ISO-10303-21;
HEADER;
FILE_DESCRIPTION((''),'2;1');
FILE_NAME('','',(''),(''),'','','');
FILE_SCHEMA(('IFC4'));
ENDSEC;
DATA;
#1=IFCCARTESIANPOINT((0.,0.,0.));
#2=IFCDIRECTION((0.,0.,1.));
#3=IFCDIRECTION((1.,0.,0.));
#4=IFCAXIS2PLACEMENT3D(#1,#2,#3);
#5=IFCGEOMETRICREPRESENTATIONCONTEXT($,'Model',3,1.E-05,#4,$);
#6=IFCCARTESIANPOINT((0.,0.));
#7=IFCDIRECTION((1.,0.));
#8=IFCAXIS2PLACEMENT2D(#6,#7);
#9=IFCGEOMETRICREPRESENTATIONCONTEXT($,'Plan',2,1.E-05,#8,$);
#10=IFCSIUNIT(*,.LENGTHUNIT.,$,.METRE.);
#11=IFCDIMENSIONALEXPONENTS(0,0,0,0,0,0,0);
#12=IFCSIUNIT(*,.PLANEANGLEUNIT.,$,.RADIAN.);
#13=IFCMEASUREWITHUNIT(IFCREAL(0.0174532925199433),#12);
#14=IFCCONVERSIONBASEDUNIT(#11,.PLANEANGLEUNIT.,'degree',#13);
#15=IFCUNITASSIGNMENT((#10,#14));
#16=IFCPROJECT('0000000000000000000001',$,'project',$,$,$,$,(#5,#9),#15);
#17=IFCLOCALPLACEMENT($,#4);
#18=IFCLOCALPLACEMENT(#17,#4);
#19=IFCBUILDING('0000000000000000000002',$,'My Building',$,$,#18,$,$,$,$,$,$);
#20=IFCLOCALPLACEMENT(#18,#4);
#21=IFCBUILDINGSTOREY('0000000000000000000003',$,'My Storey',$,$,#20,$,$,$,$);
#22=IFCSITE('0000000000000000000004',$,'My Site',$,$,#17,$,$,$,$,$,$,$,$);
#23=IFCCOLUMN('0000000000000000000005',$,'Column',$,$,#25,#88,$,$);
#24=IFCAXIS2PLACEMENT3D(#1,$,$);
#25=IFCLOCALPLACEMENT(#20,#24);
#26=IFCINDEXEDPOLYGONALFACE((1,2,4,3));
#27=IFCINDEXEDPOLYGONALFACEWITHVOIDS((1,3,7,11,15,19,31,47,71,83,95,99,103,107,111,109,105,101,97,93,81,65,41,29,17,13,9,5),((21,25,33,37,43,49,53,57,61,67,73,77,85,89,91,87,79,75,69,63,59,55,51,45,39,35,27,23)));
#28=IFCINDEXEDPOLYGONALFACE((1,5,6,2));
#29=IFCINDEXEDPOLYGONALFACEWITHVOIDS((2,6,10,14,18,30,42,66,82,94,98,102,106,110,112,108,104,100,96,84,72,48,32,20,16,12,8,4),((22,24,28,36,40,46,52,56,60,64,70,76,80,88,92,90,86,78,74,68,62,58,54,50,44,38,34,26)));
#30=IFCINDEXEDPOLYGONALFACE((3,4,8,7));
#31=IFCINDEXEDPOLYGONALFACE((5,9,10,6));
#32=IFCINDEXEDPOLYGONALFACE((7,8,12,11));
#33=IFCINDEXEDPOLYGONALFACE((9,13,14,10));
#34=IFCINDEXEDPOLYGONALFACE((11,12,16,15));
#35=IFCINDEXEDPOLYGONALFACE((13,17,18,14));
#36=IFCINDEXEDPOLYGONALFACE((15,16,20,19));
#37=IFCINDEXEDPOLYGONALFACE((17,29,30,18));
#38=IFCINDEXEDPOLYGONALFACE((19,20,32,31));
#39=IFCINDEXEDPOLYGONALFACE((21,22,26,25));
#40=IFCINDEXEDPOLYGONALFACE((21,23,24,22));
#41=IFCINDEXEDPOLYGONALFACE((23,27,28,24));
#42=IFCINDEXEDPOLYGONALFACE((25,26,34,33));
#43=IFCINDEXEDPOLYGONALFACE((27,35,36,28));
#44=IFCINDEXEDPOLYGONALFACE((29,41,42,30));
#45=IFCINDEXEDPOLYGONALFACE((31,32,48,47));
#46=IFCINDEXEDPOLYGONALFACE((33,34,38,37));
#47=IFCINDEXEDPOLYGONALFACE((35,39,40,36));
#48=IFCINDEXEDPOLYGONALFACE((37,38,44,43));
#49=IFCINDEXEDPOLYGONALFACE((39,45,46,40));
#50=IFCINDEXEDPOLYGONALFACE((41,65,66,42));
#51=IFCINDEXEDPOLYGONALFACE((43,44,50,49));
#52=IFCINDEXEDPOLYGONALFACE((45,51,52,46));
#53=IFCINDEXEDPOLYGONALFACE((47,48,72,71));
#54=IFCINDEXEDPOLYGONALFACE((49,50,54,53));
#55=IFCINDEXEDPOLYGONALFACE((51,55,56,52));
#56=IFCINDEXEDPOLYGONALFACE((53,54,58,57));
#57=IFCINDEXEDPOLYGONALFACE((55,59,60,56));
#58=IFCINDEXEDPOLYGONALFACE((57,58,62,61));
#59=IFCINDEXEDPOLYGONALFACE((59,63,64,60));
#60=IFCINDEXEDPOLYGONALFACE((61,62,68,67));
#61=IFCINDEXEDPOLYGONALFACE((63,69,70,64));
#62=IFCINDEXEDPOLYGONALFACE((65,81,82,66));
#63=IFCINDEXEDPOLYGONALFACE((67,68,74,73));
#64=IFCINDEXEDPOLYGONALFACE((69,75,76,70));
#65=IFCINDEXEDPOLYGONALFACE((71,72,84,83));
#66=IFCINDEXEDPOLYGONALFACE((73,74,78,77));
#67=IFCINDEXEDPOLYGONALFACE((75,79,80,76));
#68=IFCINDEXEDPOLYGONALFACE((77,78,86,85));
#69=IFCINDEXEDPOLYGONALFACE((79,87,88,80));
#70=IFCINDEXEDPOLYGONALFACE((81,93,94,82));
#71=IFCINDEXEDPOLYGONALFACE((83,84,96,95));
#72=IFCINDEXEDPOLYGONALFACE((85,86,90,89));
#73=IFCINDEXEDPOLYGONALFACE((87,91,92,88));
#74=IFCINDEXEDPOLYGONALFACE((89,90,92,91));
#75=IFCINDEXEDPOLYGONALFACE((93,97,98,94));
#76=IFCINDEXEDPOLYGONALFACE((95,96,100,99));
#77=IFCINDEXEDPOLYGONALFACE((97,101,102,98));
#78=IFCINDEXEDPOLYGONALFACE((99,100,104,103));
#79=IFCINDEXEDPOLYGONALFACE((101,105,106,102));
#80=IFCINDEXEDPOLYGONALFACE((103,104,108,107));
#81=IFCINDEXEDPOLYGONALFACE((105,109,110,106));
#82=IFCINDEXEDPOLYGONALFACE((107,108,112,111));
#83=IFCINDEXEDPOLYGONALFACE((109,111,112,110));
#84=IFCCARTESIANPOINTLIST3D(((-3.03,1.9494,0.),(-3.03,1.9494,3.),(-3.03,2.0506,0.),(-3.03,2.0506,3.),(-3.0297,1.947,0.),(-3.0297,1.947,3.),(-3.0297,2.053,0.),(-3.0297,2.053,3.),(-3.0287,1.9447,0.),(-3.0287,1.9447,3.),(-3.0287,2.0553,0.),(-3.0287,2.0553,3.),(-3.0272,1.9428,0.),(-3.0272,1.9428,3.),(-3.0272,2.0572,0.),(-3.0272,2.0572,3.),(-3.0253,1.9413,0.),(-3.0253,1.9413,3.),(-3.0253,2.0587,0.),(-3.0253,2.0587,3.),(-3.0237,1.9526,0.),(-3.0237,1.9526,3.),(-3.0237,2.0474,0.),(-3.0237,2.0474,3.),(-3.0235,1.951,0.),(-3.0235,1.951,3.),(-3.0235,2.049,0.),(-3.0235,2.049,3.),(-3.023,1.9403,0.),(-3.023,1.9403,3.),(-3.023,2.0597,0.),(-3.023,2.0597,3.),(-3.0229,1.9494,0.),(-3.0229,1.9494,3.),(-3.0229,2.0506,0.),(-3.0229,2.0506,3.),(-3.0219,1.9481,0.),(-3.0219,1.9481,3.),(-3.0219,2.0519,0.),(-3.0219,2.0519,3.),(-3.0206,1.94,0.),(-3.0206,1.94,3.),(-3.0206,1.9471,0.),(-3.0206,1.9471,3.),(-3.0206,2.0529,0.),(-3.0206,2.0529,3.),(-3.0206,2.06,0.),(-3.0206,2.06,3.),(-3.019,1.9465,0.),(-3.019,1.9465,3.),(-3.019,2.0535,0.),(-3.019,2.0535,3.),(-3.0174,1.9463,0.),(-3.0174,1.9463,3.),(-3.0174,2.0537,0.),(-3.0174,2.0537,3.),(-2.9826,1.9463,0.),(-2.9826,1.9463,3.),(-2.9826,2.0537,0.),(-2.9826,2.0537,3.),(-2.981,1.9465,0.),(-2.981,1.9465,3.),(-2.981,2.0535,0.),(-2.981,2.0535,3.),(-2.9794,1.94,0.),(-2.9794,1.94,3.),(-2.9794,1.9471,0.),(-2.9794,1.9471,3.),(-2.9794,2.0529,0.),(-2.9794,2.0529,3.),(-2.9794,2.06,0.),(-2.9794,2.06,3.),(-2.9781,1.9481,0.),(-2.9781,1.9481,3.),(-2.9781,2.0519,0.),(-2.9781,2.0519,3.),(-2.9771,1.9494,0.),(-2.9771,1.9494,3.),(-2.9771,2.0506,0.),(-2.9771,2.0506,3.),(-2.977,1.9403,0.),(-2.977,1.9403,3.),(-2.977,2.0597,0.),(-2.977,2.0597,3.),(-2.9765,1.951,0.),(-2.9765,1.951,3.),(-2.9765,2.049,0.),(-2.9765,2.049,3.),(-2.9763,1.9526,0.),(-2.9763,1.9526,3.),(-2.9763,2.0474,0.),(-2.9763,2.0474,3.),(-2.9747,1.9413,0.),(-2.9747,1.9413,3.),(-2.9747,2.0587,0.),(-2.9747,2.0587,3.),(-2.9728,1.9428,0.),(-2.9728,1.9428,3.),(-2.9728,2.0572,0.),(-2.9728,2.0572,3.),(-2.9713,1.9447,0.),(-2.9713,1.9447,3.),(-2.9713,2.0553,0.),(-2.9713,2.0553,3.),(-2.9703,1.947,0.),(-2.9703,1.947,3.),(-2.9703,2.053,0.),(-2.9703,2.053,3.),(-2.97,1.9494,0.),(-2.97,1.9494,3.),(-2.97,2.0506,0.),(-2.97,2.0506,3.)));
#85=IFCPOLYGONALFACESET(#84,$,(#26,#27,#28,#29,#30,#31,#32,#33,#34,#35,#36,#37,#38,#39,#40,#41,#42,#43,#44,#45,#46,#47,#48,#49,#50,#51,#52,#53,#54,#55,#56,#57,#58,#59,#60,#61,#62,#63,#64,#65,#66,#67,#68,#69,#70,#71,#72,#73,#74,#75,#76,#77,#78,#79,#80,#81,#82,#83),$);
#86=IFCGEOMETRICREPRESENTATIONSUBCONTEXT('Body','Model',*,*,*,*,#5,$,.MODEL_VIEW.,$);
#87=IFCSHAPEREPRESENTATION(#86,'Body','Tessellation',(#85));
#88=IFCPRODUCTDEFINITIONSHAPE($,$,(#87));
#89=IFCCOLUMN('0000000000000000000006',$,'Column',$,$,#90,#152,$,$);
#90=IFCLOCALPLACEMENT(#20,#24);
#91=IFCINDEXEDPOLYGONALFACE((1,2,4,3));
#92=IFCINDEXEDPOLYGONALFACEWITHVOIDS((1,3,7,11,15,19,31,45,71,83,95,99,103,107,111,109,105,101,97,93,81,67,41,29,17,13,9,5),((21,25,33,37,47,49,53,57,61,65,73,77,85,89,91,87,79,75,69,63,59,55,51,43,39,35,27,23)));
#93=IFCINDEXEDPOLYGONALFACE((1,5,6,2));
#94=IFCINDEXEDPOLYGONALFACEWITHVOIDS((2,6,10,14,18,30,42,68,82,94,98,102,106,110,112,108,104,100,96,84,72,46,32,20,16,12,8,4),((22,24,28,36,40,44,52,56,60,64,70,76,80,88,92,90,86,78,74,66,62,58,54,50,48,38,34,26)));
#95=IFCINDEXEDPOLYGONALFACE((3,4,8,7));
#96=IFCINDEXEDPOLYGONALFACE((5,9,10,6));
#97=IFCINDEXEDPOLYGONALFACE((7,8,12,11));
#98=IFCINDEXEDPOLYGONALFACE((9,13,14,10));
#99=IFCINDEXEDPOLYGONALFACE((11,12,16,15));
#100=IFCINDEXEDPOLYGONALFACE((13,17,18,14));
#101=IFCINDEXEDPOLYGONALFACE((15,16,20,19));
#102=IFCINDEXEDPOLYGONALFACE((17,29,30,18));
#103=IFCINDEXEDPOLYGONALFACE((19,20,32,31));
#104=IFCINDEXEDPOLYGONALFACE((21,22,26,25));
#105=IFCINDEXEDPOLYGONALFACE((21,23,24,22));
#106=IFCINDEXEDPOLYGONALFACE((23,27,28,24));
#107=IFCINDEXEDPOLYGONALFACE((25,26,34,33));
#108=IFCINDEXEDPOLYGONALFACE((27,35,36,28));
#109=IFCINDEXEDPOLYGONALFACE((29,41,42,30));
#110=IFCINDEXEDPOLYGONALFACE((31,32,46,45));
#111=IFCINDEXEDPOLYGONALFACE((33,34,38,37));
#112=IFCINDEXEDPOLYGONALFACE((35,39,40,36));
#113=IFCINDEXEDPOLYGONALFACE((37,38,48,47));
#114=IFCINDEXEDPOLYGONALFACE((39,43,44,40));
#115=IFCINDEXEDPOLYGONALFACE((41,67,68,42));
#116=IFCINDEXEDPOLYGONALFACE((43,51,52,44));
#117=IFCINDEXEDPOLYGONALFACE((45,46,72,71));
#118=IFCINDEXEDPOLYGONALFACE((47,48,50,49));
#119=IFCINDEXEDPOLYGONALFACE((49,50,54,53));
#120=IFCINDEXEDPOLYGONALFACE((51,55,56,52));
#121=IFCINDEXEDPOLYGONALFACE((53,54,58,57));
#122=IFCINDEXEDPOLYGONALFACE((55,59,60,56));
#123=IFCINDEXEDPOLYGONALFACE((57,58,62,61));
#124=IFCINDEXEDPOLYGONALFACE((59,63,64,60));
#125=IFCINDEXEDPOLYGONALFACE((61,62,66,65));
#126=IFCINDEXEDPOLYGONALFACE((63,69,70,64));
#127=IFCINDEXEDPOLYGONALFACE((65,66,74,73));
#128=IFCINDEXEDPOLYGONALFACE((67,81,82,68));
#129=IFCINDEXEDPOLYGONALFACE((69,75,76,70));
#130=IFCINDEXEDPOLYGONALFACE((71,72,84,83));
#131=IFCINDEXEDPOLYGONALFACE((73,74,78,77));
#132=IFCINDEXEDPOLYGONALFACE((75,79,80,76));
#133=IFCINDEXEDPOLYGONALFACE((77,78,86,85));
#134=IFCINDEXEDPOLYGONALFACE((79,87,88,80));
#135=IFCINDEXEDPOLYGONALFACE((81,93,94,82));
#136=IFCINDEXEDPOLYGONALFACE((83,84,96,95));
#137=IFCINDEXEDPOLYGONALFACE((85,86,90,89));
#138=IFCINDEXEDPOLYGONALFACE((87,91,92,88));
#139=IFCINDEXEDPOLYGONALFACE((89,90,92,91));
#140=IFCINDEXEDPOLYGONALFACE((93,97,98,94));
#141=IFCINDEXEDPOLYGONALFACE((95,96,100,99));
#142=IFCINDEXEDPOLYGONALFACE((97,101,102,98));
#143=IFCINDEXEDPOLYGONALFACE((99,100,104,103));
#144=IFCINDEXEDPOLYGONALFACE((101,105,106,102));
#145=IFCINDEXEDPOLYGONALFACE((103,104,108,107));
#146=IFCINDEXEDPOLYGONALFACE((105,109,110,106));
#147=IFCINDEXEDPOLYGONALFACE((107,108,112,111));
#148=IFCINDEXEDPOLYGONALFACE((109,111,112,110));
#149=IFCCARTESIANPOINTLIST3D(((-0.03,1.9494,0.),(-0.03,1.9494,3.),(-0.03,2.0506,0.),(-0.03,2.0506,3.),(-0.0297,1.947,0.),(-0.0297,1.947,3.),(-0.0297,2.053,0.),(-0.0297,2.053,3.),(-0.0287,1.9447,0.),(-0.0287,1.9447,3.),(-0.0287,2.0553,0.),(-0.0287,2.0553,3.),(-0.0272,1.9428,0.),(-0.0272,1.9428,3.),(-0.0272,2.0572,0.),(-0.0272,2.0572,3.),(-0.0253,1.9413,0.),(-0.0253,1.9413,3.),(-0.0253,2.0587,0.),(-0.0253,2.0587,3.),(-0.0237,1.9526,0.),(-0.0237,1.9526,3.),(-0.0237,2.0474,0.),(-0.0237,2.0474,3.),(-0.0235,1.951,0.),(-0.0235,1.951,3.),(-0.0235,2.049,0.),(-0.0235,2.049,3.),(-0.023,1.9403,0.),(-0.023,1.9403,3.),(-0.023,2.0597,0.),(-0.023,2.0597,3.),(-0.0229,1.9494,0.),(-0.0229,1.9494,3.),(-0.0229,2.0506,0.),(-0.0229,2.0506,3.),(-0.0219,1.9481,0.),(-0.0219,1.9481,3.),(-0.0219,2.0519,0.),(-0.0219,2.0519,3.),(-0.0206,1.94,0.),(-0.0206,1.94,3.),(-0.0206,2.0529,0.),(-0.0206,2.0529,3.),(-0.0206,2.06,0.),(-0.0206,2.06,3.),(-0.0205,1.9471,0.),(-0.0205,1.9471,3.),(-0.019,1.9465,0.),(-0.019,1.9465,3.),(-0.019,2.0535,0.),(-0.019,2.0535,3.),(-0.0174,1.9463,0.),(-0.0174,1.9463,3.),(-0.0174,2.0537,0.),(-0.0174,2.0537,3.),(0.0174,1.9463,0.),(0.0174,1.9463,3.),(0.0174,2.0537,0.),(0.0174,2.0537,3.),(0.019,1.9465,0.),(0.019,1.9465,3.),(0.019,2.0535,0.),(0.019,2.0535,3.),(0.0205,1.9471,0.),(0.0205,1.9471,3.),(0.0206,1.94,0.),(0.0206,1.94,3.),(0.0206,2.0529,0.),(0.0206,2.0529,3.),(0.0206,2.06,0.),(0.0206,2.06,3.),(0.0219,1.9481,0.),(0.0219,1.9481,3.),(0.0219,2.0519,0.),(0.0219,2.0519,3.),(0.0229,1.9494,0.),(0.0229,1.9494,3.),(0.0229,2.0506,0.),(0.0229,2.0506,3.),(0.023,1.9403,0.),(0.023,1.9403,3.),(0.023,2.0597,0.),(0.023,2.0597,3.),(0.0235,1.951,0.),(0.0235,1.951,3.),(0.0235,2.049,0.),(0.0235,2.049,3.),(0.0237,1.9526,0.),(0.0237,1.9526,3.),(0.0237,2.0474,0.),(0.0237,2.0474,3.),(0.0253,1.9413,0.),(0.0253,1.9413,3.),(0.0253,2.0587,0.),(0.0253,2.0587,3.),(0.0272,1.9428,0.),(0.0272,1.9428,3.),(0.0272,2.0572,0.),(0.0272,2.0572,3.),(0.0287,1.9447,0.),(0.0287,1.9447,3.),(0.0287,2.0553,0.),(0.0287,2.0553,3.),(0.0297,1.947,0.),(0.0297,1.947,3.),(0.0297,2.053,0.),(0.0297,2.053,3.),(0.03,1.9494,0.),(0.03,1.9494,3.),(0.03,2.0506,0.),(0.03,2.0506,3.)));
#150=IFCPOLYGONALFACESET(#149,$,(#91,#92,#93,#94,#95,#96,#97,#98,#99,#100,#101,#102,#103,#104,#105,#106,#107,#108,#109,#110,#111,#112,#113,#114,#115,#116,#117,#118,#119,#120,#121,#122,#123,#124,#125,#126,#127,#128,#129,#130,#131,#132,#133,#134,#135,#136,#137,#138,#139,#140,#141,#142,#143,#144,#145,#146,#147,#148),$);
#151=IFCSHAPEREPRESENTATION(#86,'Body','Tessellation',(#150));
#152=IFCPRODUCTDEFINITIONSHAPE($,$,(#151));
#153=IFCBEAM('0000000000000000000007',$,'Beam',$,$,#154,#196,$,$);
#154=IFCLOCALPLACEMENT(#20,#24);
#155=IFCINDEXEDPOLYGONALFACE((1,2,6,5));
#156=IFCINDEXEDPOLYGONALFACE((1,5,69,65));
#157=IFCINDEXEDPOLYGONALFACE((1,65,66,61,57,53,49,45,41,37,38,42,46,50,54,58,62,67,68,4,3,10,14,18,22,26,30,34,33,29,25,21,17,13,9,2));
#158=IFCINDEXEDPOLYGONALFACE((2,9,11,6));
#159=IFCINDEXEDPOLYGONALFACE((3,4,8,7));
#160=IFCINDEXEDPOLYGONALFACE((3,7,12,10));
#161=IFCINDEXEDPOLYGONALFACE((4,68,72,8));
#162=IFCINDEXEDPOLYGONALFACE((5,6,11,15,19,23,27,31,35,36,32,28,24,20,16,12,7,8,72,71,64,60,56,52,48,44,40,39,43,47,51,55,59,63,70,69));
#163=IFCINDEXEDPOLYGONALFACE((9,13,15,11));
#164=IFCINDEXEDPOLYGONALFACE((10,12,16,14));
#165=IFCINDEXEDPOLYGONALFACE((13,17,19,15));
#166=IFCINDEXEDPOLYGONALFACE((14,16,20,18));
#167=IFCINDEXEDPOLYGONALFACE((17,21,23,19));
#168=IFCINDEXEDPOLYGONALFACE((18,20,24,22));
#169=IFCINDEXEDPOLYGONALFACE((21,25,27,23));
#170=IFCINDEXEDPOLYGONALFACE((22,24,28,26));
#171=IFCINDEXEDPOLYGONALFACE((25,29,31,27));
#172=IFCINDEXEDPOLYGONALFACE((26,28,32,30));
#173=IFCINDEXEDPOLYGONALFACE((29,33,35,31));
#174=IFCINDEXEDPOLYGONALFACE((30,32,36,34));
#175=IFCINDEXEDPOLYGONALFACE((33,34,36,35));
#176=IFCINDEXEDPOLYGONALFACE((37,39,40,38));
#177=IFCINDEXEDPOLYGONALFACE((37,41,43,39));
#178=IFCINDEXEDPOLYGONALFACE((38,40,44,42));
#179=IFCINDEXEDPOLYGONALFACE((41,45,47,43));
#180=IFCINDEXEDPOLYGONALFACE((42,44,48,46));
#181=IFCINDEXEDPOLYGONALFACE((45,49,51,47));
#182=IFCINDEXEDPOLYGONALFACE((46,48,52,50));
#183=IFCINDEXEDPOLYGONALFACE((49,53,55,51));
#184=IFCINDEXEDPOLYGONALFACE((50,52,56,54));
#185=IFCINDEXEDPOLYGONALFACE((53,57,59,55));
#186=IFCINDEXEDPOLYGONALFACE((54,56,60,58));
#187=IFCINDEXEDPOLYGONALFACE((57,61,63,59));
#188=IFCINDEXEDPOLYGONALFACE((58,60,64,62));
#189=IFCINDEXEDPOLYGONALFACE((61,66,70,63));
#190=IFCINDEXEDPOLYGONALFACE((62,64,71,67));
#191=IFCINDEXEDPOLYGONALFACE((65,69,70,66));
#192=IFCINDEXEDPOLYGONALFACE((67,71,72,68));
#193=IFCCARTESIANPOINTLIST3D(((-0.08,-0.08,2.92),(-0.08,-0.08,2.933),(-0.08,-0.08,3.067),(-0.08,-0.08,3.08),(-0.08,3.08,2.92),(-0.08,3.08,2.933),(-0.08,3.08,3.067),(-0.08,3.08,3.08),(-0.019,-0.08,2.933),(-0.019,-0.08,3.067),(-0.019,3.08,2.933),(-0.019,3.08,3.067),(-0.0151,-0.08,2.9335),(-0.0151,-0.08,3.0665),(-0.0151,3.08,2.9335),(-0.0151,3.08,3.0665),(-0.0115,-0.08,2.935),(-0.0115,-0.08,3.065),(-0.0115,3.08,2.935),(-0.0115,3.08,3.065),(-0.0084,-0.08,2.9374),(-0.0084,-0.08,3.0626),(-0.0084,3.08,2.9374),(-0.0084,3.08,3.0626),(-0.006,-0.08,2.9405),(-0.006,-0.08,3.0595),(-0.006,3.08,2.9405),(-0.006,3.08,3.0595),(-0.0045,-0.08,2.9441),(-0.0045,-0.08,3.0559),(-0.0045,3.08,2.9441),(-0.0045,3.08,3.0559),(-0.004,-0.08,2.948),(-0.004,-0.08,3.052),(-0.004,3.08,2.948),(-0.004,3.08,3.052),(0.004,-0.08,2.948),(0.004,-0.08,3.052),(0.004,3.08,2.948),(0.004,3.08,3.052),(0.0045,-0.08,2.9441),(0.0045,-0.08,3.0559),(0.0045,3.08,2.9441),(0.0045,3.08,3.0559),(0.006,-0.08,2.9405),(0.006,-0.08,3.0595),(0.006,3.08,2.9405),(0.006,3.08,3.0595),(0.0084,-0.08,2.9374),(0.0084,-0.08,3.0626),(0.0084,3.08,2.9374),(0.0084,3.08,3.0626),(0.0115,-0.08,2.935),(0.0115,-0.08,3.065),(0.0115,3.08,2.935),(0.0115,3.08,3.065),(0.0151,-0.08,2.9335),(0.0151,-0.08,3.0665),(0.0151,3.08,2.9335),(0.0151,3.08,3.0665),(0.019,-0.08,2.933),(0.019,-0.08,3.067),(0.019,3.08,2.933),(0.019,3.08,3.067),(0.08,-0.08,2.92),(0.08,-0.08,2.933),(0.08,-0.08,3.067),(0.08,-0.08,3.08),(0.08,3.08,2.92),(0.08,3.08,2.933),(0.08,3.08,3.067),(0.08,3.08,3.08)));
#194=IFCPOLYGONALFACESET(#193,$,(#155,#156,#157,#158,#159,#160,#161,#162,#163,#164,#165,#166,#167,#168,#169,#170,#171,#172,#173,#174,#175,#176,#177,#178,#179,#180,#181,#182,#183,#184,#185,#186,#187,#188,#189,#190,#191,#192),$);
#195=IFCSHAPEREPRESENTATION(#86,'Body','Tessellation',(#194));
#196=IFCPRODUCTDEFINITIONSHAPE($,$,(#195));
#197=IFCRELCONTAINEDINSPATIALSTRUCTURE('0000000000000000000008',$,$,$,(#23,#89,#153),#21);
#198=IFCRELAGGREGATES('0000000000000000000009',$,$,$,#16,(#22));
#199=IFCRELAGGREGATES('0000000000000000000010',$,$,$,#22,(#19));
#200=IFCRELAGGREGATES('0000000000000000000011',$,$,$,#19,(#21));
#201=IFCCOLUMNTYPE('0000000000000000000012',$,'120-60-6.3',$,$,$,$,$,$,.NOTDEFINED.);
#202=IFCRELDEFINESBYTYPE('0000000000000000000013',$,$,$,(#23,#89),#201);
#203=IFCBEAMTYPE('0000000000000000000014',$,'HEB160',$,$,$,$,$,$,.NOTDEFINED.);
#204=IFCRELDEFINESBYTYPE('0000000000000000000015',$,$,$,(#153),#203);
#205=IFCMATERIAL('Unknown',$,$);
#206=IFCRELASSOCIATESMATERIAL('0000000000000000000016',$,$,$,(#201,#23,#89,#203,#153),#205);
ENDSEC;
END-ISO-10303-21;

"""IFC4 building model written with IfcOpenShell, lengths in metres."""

from ifc_helpers import new_model, entity, si_unit, converted_unit, frame, origin_with_axes, origin_2d_with_axis, place, context, subcontext, project, spatial, hollow_rectangle, i_section, extrude, material, material_profile, profile_set, profile_usage, type_object, element, save


model = new_model("IFC4")

# Units and contexts
model_context = context("Model", 3, precision=1e-05, world=origin_with_axes())
plan_context = context("Plan", 2, precision=1e-05, world=origin_2d_with_axis())
body_context = subcontext(model_context, "Body", "Model", "MODEL_VIEW")
ifc_project = project(units=[si_unit("LENGTHUNIT", "METRE"), converted_unit("PLANEANGLEUNIT", "degree", entity("IfcReal", 0.0174532925199433), si_unit("PLANEANGLEUNIT", "RADIAN"), dimensions=[0, 0, 0, 0, 0, 0, 0])], contexts=[model_context, plan_context])

# Site, building, storey
site_placement = place(None, origin_with_axes())
site = spatial("IfcSite", under=ifc_project, at=site_placement, Name="My Site")
building_placement = place(site_placement, origin_with_axes())
building = spatial("IfcBuilding", under=site, at=building_placement, Name="My Building")
storey_placement = place(building_placement, origin_with_axes())
storey = spatial("IfcBuildingStorey", under=building, at=storey_placement, Name="My Storey")

# Columns
ifc_material = material(Name="Unknown")
ifc_material_profile_1 = material_profile(ifc_material, hollow_rectangle(XDim=0.06, YDim=0.12, WallThickness=0.0063, InnerFilletRadius=0.0063, OuterFilletRadius=0.0095))
ifc_profile_set_1 = profile_set([ifc_material_profile_1])
column_type = type_object("IfcColumnType", Name="120-60-6.3", PredefinedType="NOTDEFINED", material=ifc_profile_set_1)
ifc_profile_usage_1 = profile_usage(ifc_profile_set_1, cardinal=5)
column_1_placement = place(storey_placement, frame((-3.0, 2.0, 0.0), z_axis=(0.0, 0.0, 1.0), x_axis=(1.0, 0.0, 0.0)))
element("IfcColumn", 1, at=column_1_placement, inside=storey, type_object=column_type, material=ifc_profile_usage_1, Name="Column", context=body_context, shape_type="SweptSolid", body=[
    extrude(hollow_rectangle(XDim=0.06, YDim=0.12, WallThickness=0.0063, InnerFilletRadius=0.0063, OuterFilletRadius=0.0095), origin_with_axes(), (0.0, 0.0, 1.0), 3.0),
])
ifc_profile_usage_2 = profile_usage(ifc_profile_set_1, cardinal=5)
column_2_placement = place(storey_placement, frame((0.0, 2.0, 0.0), z_axis=(0.0, 0.0, 1.0), x_axis=(1.0, 0.0, 0.0)))
element("IfcColumn", 2, at=column_2_placement, inside=storey, type_object=column_type, material=ifc_profile_usage_2, Name="Column", context=body_context, shape_type="SweptSolid", body=[
    extrude(hollow_rectangle(XDim=0.06, YDim=0.12, WallThickness=0.0063, InnerFilletRadius=0.0063, OuterFilletRadius=0.0095), origin_with_axes(), (0.0, 0.0, 1.0), 3.0),
])

# Beam
ifc_material_profile_2 = material_profile(ifc_material, i_section(OverallWidth=0.16, OverallDepth=0.16, WebThickness=0.008, FlangeThickness=0.013, FilletRadius=0.015))
ifc_profile_set_2 = profile_set([ifc_material_profile_2])
ifc_profile_usage_3 = profile_usage(ifc_profile_set_2, cardinal=5)
beam_type = type_object("IfcBeamType", Name="HEB160", PredefinedType="NOTDEFINED", material=ifc_profile_set_2)
beam_1_placement = place(storey_placement, frame((0.0, -0.08, 3.0), z_axis=(0.0, 1.0, 0.0), x_axis=(-1.0, 0.0, 0.0)))
element("IfcBeam", 3, at=beam_1_placement, inside=storey, type_object=beam_type, material=ifc_profile_usage_3, Name="Beam", context=body_context, shape_type="SweptSolid", body=[
    extrude(i_section(OverallWidth=0.16, OverallDepth=0.16, WebThickness=0.008, FlangeThickness=0.013, FilletRadius=0.015), origin_with_axes(), (0.0, 0.0, 1.0), 3.16),
])

save(model, "model.ifc")
